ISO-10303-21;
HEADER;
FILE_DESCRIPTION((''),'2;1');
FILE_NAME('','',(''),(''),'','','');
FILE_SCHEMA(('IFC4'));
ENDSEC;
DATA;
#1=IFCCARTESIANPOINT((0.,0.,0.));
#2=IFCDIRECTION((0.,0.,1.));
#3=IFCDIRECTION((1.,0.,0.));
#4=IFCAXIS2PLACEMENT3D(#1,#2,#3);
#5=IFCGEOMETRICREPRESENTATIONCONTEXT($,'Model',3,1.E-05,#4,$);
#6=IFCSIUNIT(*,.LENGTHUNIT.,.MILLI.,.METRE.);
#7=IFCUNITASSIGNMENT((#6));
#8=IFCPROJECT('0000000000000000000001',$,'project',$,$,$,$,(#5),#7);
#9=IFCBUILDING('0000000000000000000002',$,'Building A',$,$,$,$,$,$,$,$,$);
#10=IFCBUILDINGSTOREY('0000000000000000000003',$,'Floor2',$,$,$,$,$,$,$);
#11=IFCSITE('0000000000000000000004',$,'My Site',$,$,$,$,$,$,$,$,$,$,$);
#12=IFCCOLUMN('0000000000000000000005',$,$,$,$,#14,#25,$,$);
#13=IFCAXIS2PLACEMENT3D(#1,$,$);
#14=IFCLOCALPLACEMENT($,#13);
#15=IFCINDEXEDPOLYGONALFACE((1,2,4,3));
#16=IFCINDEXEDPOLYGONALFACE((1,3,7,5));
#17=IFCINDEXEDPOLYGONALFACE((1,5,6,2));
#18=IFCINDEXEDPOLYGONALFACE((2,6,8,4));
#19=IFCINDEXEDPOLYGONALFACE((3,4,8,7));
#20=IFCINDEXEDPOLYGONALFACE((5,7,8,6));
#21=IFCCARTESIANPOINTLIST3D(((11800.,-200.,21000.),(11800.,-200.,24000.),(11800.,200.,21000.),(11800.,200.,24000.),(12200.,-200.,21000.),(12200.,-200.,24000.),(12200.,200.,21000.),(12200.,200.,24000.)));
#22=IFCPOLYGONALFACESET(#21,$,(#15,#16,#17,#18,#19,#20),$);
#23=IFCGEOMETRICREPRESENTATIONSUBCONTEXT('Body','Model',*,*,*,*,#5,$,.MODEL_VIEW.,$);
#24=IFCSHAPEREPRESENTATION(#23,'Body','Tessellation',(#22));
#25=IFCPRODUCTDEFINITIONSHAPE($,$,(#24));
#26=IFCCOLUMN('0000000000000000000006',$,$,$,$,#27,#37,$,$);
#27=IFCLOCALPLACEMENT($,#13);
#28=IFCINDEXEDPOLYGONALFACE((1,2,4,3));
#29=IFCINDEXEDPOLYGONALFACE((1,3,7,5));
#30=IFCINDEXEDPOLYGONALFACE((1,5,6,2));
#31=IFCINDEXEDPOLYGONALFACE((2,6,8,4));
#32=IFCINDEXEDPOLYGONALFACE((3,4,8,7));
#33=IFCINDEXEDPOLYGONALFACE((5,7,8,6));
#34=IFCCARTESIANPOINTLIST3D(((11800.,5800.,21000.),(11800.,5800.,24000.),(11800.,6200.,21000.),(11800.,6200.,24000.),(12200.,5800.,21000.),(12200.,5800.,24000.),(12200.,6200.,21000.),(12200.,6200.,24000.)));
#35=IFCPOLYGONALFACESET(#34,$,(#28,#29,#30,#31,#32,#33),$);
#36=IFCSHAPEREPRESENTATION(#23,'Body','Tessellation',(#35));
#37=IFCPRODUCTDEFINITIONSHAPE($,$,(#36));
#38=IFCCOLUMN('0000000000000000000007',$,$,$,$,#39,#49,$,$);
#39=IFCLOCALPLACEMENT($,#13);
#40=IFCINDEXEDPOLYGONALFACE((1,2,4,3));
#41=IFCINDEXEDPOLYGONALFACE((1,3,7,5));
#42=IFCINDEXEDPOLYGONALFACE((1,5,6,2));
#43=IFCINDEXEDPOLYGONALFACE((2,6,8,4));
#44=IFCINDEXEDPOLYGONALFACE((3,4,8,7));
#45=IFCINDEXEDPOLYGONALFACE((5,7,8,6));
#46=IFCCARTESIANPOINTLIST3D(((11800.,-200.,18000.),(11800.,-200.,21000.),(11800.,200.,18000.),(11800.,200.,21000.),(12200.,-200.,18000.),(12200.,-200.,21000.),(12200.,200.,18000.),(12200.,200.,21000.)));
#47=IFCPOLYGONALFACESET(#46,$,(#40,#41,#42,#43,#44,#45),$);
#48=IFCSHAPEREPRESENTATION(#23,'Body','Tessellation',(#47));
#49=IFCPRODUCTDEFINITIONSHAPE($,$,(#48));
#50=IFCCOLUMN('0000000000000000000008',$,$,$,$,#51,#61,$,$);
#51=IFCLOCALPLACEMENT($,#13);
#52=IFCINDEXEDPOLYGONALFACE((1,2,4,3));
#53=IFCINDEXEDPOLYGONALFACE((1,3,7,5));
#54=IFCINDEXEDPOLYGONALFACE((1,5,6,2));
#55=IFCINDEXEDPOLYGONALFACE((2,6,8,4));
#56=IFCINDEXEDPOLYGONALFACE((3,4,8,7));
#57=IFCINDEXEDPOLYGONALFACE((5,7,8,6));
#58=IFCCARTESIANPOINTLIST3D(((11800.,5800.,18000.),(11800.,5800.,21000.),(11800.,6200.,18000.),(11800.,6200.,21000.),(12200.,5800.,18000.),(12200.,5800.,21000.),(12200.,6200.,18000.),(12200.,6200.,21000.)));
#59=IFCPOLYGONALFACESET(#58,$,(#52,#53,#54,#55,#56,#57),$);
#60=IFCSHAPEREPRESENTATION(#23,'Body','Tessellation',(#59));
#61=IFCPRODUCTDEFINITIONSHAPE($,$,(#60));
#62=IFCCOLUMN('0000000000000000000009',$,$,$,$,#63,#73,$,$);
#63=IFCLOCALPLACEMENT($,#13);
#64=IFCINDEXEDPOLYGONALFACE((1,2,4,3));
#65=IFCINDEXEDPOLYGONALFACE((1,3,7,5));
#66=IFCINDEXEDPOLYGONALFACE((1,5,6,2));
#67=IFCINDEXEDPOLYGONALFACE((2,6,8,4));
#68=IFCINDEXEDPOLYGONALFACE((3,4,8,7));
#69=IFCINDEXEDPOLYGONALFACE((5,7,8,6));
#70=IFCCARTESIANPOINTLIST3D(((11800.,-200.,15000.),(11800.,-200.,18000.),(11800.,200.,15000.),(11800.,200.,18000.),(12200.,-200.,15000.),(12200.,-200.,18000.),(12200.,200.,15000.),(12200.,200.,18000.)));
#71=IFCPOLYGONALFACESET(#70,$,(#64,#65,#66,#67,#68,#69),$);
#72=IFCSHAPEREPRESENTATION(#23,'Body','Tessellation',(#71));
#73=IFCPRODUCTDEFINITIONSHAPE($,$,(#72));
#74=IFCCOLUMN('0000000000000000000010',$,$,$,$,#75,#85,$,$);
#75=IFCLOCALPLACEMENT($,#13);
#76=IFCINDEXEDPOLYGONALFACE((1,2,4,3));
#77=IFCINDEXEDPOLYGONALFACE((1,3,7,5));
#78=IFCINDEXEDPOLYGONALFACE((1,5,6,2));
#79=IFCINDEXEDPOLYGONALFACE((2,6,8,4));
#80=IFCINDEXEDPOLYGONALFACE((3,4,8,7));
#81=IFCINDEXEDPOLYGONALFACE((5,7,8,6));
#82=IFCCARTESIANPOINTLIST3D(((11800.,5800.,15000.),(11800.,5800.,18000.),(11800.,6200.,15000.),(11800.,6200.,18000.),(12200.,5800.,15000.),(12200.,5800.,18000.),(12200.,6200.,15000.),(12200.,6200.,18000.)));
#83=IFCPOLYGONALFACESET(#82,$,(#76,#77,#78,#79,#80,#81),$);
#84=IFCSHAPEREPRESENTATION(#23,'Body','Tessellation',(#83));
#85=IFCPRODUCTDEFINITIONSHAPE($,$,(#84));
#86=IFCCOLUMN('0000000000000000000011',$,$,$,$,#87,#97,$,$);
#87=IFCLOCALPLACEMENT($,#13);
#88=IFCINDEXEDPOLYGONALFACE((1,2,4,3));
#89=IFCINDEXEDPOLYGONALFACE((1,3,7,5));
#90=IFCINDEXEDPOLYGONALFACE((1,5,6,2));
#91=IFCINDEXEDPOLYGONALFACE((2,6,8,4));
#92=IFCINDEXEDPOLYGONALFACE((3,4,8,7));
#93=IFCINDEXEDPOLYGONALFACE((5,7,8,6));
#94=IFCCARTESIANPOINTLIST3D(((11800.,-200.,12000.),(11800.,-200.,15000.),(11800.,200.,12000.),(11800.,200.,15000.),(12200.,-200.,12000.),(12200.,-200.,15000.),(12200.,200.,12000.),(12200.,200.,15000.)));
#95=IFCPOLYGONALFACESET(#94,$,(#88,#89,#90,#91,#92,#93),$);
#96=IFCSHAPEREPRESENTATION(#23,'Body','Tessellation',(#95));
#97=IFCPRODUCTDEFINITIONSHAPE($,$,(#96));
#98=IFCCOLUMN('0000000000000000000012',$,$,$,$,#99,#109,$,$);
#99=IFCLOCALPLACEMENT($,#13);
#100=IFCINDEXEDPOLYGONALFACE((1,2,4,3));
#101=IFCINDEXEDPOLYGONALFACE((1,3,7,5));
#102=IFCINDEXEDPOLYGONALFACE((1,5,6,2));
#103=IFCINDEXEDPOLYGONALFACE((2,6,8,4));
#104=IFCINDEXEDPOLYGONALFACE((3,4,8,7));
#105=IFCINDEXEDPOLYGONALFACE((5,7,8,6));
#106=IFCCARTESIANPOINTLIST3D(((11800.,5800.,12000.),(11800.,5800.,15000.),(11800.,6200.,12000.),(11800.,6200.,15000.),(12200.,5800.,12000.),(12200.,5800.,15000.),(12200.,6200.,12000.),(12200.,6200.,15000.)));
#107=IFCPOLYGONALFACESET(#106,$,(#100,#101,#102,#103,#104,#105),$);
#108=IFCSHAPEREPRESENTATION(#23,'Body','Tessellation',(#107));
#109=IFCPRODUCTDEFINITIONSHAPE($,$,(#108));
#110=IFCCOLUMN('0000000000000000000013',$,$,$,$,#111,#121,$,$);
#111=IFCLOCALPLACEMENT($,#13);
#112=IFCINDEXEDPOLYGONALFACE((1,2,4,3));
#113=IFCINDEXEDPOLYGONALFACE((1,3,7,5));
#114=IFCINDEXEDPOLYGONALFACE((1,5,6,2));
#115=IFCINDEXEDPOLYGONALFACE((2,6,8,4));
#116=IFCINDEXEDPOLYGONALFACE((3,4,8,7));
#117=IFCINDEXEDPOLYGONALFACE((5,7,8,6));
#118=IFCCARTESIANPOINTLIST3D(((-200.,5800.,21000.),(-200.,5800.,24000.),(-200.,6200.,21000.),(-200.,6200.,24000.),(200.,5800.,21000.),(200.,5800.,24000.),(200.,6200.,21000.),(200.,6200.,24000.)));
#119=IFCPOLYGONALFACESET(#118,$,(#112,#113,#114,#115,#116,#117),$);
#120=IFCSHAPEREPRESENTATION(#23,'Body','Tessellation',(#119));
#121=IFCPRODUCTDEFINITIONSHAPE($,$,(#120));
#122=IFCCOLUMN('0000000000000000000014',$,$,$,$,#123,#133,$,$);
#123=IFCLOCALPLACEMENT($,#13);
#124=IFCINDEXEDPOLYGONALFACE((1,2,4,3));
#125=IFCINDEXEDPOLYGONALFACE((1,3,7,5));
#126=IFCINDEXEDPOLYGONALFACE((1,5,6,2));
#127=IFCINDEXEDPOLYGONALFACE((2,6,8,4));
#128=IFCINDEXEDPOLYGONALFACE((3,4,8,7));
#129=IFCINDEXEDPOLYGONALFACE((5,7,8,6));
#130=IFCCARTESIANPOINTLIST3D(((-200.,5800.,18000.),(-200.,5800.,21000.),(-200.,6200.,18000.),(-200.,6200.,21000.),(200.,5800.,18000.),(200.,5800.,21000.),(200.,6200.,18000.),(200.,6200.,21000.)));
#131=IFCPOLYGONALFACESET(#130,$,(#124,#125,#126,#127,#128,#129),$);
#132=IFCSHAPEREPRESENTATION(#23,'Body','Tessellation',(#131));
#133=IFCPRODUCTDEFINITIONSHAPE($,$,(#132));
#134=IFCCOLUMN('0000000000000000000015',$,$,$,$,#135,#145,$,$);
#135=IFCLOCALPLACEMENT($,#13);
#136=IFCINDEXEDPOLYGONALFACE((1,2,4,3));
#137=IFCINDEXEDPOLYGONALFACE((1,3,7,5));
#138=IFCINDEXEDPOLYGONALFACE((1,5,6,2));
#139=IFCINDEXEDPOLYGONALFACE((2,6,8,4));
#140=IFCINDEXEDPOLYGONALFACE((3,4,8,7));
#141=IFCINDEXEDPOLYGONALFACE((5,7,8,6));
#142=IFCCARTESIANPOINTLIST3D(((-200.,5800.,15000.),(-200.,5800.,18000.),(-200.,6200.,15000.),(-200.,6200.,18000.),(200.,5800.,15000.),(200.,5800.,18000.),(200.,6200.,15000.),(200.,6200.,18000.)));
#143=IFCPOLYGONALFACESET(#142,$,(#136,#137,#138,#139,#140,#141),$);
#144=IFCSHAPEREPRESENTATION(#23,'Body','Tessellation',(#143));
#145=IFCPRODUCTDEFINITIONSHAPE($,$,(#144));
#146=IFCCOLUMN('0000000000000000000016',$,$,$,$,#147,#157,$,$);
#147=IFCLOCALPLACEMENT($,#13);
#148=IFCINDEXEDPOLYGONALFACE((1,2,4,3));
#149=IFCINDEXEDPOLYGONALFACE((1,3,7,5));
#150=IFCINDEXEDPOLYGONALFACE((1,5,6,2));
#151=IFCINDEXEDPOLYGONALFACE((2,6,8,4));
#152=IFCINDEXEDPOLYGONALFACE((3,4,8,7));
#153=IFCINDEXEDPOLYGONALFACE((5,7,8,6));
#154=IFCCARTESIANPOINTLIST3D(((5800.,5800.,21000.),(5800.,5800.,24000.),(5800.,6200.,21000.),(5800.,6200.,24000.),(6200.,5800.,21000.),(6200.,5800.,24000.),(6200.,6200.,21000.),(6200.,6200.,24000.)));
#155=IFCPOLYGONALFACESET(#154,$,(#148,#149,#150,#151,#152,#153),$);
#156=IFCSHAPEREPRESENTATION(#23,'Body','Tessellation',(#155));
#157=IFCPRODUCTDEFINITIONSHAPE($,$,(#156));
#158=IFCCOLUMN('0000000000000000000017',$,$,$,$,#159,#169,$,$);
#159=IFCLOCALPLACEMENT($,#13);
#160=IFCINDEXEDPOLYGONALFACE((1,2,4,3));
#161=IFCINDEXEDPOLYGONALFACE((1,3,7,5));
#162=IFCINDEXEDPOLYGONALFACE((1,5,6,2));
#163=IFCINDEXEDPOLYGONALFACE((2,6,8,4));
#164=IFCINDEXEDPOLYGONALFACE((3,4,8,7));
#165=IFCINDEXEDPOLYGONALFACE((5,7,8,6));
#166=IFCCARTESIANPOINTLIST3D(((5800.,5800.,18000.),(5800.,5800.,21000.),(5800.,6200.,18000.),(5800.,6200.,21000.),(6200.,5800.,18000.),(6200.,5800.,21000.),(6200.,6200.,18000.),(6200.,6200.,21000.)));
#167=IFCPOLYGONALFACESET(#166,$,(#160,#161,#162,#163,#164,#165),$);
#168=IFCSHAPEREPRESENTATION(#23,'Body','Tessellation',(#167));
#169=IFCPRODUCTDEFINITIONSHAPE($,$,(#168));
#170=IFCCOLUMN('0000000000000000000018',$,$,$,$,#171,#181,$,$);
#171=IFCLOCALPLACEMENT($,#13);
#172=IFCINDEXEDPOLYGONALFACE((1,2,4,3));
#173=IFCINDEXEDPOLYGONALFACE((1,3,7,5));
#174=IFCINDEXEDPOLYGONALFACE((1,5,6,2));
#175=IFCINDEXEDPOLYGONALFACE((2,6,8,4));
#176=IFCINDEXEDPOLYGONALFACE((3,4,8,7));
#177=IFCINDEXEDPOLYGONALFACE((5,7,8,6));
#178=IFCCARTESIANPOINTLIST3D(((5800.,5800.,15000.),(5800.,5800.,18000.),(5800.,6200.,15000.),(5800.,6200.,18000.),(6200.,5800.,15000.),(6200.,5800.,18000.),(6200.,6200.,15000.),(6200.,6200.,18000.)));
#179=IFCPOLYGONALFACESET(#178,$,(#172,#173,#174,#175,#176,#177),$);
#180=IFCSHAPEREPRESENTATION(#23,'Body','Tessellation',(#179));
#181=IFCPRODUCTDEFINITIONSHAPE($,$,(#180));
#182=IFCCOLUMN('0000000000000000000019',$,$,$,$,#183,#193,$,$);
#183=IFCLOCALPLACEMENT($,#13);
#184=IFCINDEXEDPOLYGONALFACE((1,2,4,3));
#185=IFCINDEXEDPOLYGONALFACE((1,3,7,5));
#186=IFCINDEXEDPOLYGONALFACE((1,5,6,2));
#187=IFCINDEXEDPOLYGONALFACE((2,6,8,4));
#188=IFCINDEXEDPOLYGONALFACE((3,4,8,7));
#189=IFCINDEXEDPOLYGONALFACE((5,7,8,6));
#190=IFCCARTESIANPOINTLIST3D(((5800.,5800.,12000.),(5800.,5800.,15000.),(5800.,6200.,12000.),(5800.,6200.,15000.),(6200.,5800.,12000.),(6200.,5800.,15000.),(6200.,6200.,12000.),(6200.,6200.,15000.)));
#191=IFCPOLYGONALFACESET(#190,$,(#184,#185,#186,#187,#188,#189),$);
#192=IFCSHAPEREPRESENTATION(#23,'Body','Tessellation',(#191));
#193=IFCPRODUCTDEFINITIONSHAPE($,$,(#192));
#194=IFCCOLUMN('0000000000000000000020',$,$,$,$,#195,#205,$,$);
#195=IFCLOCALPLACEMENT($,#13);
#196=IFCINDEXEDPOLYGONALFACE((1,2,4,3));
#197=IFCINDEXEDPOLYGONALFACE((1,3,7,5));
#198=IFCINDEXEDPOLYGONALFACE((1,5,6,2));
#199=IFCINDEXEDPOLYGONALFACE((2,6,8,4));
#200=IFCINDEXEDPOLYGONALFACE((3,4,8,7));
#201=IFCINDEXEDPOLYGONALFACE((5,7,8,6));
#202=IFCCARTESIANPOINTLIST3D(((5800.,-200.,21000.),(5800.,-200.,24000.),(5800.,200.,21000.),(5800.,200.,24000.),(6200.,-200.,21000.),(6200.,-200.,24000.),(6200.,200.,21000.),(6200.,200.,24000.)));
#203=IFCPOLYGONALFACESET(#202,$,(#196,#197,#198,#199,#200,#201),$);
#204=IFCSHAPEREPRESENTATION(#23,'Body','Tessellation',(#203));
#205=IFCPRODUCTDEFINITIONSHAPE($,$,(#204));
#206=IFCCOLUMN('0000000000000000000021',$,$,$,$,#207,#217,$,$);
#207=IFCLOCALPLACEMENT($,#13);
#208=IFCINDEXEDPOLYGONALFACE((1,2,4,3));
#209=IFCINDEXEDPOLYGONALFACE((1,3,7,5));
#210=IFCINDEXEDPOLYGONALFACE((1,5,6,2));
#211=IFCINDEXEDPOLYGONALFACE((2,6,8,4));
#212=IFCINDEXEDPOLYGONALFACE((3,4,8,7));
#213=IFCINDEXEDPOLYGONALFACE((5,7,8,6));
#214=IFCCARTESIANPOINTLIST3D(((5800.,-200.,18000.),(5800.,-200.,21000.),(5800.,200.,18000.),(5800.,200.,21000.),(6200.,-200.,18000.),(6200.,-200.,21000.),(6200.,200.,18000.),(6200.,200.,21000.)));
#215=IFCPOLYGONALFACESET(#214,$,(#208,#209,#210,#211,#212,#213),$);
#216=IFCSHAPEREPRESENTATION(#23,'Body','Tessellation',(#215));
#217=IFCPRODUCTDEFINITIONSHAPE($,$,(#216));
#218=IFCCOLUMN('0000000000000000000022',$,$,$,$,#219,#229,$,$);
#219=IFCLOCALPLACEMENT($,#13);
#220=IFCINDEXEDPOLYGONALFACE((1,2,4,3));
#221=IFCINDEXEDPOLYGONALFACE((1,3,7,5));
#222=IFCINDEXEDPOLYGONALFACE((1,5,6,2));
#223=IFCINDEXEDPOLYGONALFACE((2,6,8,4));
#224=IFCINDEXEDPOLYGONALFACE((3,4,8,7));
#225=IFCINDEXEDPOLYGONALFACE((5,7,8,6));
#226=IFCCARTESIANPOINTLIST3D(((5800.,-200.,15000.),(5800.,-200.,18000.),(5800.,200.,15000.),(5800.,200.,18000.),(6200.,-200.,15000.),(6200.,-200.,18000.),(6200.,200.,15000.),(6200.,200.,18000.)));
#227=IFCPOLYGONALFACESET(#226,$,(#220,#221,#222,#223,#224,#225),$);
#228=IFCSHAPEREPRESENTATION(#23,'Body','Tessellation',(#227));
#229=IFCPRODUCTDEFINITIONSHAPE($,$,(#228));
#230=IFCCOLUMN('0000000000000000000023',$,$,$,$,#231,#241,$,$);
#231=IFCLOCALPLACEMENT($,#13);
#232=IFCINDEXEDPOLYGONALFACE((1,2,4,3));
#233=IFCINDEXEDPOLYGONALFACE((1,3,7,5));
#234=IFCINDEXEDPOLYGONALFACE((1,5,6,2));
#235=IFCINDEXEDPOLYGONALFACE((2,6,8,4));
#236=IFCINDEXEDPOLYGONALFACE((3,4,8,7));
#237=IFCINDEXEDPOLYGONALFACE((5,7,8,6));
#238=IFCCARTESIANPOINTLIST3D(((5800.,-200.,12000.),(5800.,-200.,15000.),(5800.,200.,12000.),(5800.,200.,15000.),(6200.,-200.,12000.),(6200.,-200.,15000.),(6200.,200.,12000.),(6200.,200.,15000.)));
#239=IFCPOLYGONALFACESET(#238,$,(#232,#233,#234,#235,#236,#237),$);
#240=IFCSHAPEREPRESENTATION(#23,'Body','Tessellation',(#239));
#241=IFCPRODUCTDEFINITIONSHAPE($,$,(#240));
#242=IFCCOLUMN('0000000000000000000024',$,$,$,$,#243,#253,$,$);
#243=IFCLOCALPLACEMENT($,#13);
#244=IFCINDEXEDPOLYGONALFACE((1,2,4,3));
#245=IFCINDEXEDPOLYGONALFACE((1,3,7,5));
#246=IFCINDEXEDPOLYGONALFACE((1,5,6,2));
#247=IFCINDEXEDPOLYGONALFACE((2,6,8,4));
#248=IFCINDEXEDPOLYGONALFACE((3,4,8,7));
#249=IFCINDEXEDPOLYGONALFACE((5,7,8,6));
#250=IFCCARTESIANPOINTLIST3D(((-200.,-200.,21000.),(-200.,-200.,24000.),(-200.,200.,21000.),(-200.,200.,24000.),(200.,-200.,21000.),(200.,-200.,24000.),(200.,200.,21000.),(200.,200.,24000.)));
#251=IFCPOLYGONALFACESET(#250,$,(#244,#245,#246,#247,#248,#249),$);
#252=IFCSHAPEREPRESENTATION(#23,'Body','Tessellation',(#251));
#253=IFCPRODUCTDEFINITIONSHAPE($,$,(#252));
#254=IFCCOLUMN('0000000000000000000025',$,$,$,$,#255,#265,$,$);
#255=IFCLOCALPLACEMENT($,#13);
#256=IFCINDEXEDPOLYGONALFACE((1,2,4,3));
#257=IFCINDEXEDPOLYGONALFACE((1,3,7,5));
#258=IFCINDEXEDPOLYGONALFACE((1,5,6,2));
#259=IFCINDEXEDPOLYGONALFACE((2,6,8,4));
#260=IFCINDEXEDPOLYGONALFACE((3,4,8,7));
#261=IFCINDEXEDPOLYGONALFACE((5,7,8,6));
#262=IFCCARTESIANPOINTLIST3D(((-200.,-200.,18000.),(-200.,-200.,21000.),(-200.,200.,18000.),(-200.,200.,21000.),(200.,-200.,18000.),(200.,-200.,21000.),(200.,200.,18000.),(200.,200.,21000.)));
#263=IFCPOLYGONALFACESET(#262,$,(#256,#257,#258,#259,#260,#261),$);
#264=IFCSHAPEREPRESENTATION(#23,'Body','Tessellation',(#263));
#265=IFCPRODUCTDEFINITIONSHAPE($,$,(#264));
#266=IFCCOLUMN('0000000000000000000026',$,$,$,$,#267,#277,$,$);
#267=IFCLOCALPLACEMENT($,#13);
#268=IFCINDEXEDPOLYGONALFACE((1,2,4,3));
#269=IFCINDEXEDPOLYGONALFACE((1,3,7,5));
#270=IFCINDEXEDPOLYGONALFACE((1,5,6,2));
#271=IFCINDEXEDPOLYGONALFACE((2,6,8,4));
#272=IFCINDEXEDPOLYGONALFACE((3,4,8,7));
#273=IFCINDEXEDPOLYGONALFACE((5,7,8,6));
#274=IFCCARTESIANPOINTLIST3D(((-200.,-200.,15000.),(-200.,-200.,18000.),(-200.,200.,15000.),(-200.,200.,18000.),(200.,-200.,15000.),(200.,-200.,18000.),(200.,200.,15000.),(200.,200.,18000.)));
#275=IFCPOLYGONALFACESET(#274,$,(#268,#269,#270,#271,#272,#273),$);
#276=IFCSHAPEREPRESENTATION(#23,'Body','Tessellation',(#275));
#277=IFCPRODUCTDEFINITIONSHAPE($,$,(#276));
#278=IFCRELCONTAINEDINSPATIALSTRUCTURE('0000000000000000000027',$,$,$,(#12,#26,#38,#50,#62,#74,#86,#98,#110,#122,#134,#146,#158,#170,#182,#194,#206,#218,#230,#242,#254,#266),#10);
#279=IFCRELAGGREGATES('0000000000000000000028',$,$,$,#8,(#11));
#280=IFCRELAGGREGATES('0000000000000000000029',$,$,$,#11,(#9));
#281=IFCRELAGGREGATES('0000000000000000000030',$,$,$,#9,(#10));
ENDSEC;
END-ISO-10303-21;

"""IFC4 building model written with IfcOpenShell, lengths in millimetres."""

from ifc_helpers import new_model, si_unit, frame, origin_with_axes, place, context, subcontext, project, spatial, line, indexed_curve, outline, extrude, element, save


model = new_model("IFC4")

# Units and contexts
model_context = context("Model", 3, precision=1e-05, world=origin_with_axes())
body_context = subcontext(model_context, "Body", "Model", "MODEL_VIEW")
ifc_project = project(units=[si_unit("LENGTHUNIT", "METRE", prefix="MILLI")], contexts=[model_context])

# Site, building, storey
site = spatial("IfcSite", under=ifc_project, Name="My Site")
building = spatial("IfcBuilding", under=site, Name="Building A")
storey = spatial("IfcBuildingStorey", under=building, Name="Floor2")

# Columns
for number, where, z_axis, x_axis in (
    (1, (12000.0, 0.0, 21000.0), (0.0, 0.0, 1.0), (1.0, 0.0, 0.0)),
    (2, (12000.0, 6000.0, 21000.0), (0.0, 0.0, 1.0), (1.0, 0.0, 0.0)),
    (3, (12000.0, 0.0, 18000.0), (0.0, 0.0, 1.0), (1.0, 0.0, 0.0)),
    (4, (12000.0, 6000.0, 18000.0), (0.0, 0.0, 1.0), (1.0, 0.0, 0.0)),
    (5, (12000.0, 0.0, 15000.0), (0.0, 0.0, 1.0), (1.0, 0.0, 0.0)),
    (6, (12000.0, 6000.0, 15000.0), (0.0, 0.0, 1.0), (1.0, 0.0, 0.0)),
    (7, (12000.0, 0.0, 12000.0), (0.0, 0.0, 1.0), (1.0, 0.0, 0.0)),
    (8, (12000.0, 6000.0, 12000.0), (0.0, 0.0, 1.0), (1.0, 0.0, 0.0)),
    (9, (0.0, 6000.0, 21000.0), (0.0, 0.0, 1.0), (1.0, 0.0, 0.0)),
    (10, (0.0, 6000.0, 18000.0), (0.0, 0.0, 1.0), (1.0, 0.0, 0.0)),
    (11, (0.0, 6000.0, 15000.0), (0.0, 0.0, 1.0), (1.0, 0.0, 0.0)),
    (12, (6000.0, 6000.0, 21000.0), (0.0, 0.0, 1.0), (1.0, 0.0, 0.0)),
    (13, (6000.0, 6000.0, 18000.0), (0.0, 0.0, 1.0), (1.0, 0.0, 0.0)),
    (14, (6000.0, 6000.0, 15000.0), (0.0, 0.0, 1.0), (1.0, 0.0, 0.0)),
    (15, (6000.0, 6000.0, 12000.0), (0.0, 0.0, 1.0), (1.0, 0.0, 0.0)),
    (16, (6000.0, 0.0, 21000.0), (0.0, 0.0, 1.0), (1.0, 0.0, 0.0)),
    (17, (6000.0, 0.0, 18000.0), (0.0, 0.0, 1.0), (1.0, 0.0, 0.0)),
    (18, (6000.0, 0.0, 15000.0), (0.0, 0.0, 1.0), (1.0, 0.0, 0.0)),
    (19, (6000.0, 0.0, 12000.0), (0.0, 0.0, 1.0), (1.0, 0.0, 0.0)),
    (20, (0.0, 0.0, 21000.0), (0.0, 0.0, 1.0), (1.0, 0.0, 0.0)),
    (21, (0.0, 0.0, 18000.0), (0.0, 0.0, 1.0), (1.0, 0.0, 0.0)),
    (22, (0.0, 0.0, 15000.0), (0.0, 0.0, 1.0), (1.0, 0.0, 0.0)),
):
    element("IfcColumn", number, at=place(None, frame(where, z_axis=z_axis, x_axis=x_axis)), inside=storey, context=body_context, shape_type="SweptSolid", body=[
        extrude(outline(indexed_curve([(-200.0, -200.0), (200.0, -200.0), (200.0, 200.0), (-200.0, 200.0)], segments=[line(1, 2, 3, 4, 1)])), origin_with_axes(), (0.0, 0.0, 1.0), 3000.0),
    ])

save(model, "model.ifc")
